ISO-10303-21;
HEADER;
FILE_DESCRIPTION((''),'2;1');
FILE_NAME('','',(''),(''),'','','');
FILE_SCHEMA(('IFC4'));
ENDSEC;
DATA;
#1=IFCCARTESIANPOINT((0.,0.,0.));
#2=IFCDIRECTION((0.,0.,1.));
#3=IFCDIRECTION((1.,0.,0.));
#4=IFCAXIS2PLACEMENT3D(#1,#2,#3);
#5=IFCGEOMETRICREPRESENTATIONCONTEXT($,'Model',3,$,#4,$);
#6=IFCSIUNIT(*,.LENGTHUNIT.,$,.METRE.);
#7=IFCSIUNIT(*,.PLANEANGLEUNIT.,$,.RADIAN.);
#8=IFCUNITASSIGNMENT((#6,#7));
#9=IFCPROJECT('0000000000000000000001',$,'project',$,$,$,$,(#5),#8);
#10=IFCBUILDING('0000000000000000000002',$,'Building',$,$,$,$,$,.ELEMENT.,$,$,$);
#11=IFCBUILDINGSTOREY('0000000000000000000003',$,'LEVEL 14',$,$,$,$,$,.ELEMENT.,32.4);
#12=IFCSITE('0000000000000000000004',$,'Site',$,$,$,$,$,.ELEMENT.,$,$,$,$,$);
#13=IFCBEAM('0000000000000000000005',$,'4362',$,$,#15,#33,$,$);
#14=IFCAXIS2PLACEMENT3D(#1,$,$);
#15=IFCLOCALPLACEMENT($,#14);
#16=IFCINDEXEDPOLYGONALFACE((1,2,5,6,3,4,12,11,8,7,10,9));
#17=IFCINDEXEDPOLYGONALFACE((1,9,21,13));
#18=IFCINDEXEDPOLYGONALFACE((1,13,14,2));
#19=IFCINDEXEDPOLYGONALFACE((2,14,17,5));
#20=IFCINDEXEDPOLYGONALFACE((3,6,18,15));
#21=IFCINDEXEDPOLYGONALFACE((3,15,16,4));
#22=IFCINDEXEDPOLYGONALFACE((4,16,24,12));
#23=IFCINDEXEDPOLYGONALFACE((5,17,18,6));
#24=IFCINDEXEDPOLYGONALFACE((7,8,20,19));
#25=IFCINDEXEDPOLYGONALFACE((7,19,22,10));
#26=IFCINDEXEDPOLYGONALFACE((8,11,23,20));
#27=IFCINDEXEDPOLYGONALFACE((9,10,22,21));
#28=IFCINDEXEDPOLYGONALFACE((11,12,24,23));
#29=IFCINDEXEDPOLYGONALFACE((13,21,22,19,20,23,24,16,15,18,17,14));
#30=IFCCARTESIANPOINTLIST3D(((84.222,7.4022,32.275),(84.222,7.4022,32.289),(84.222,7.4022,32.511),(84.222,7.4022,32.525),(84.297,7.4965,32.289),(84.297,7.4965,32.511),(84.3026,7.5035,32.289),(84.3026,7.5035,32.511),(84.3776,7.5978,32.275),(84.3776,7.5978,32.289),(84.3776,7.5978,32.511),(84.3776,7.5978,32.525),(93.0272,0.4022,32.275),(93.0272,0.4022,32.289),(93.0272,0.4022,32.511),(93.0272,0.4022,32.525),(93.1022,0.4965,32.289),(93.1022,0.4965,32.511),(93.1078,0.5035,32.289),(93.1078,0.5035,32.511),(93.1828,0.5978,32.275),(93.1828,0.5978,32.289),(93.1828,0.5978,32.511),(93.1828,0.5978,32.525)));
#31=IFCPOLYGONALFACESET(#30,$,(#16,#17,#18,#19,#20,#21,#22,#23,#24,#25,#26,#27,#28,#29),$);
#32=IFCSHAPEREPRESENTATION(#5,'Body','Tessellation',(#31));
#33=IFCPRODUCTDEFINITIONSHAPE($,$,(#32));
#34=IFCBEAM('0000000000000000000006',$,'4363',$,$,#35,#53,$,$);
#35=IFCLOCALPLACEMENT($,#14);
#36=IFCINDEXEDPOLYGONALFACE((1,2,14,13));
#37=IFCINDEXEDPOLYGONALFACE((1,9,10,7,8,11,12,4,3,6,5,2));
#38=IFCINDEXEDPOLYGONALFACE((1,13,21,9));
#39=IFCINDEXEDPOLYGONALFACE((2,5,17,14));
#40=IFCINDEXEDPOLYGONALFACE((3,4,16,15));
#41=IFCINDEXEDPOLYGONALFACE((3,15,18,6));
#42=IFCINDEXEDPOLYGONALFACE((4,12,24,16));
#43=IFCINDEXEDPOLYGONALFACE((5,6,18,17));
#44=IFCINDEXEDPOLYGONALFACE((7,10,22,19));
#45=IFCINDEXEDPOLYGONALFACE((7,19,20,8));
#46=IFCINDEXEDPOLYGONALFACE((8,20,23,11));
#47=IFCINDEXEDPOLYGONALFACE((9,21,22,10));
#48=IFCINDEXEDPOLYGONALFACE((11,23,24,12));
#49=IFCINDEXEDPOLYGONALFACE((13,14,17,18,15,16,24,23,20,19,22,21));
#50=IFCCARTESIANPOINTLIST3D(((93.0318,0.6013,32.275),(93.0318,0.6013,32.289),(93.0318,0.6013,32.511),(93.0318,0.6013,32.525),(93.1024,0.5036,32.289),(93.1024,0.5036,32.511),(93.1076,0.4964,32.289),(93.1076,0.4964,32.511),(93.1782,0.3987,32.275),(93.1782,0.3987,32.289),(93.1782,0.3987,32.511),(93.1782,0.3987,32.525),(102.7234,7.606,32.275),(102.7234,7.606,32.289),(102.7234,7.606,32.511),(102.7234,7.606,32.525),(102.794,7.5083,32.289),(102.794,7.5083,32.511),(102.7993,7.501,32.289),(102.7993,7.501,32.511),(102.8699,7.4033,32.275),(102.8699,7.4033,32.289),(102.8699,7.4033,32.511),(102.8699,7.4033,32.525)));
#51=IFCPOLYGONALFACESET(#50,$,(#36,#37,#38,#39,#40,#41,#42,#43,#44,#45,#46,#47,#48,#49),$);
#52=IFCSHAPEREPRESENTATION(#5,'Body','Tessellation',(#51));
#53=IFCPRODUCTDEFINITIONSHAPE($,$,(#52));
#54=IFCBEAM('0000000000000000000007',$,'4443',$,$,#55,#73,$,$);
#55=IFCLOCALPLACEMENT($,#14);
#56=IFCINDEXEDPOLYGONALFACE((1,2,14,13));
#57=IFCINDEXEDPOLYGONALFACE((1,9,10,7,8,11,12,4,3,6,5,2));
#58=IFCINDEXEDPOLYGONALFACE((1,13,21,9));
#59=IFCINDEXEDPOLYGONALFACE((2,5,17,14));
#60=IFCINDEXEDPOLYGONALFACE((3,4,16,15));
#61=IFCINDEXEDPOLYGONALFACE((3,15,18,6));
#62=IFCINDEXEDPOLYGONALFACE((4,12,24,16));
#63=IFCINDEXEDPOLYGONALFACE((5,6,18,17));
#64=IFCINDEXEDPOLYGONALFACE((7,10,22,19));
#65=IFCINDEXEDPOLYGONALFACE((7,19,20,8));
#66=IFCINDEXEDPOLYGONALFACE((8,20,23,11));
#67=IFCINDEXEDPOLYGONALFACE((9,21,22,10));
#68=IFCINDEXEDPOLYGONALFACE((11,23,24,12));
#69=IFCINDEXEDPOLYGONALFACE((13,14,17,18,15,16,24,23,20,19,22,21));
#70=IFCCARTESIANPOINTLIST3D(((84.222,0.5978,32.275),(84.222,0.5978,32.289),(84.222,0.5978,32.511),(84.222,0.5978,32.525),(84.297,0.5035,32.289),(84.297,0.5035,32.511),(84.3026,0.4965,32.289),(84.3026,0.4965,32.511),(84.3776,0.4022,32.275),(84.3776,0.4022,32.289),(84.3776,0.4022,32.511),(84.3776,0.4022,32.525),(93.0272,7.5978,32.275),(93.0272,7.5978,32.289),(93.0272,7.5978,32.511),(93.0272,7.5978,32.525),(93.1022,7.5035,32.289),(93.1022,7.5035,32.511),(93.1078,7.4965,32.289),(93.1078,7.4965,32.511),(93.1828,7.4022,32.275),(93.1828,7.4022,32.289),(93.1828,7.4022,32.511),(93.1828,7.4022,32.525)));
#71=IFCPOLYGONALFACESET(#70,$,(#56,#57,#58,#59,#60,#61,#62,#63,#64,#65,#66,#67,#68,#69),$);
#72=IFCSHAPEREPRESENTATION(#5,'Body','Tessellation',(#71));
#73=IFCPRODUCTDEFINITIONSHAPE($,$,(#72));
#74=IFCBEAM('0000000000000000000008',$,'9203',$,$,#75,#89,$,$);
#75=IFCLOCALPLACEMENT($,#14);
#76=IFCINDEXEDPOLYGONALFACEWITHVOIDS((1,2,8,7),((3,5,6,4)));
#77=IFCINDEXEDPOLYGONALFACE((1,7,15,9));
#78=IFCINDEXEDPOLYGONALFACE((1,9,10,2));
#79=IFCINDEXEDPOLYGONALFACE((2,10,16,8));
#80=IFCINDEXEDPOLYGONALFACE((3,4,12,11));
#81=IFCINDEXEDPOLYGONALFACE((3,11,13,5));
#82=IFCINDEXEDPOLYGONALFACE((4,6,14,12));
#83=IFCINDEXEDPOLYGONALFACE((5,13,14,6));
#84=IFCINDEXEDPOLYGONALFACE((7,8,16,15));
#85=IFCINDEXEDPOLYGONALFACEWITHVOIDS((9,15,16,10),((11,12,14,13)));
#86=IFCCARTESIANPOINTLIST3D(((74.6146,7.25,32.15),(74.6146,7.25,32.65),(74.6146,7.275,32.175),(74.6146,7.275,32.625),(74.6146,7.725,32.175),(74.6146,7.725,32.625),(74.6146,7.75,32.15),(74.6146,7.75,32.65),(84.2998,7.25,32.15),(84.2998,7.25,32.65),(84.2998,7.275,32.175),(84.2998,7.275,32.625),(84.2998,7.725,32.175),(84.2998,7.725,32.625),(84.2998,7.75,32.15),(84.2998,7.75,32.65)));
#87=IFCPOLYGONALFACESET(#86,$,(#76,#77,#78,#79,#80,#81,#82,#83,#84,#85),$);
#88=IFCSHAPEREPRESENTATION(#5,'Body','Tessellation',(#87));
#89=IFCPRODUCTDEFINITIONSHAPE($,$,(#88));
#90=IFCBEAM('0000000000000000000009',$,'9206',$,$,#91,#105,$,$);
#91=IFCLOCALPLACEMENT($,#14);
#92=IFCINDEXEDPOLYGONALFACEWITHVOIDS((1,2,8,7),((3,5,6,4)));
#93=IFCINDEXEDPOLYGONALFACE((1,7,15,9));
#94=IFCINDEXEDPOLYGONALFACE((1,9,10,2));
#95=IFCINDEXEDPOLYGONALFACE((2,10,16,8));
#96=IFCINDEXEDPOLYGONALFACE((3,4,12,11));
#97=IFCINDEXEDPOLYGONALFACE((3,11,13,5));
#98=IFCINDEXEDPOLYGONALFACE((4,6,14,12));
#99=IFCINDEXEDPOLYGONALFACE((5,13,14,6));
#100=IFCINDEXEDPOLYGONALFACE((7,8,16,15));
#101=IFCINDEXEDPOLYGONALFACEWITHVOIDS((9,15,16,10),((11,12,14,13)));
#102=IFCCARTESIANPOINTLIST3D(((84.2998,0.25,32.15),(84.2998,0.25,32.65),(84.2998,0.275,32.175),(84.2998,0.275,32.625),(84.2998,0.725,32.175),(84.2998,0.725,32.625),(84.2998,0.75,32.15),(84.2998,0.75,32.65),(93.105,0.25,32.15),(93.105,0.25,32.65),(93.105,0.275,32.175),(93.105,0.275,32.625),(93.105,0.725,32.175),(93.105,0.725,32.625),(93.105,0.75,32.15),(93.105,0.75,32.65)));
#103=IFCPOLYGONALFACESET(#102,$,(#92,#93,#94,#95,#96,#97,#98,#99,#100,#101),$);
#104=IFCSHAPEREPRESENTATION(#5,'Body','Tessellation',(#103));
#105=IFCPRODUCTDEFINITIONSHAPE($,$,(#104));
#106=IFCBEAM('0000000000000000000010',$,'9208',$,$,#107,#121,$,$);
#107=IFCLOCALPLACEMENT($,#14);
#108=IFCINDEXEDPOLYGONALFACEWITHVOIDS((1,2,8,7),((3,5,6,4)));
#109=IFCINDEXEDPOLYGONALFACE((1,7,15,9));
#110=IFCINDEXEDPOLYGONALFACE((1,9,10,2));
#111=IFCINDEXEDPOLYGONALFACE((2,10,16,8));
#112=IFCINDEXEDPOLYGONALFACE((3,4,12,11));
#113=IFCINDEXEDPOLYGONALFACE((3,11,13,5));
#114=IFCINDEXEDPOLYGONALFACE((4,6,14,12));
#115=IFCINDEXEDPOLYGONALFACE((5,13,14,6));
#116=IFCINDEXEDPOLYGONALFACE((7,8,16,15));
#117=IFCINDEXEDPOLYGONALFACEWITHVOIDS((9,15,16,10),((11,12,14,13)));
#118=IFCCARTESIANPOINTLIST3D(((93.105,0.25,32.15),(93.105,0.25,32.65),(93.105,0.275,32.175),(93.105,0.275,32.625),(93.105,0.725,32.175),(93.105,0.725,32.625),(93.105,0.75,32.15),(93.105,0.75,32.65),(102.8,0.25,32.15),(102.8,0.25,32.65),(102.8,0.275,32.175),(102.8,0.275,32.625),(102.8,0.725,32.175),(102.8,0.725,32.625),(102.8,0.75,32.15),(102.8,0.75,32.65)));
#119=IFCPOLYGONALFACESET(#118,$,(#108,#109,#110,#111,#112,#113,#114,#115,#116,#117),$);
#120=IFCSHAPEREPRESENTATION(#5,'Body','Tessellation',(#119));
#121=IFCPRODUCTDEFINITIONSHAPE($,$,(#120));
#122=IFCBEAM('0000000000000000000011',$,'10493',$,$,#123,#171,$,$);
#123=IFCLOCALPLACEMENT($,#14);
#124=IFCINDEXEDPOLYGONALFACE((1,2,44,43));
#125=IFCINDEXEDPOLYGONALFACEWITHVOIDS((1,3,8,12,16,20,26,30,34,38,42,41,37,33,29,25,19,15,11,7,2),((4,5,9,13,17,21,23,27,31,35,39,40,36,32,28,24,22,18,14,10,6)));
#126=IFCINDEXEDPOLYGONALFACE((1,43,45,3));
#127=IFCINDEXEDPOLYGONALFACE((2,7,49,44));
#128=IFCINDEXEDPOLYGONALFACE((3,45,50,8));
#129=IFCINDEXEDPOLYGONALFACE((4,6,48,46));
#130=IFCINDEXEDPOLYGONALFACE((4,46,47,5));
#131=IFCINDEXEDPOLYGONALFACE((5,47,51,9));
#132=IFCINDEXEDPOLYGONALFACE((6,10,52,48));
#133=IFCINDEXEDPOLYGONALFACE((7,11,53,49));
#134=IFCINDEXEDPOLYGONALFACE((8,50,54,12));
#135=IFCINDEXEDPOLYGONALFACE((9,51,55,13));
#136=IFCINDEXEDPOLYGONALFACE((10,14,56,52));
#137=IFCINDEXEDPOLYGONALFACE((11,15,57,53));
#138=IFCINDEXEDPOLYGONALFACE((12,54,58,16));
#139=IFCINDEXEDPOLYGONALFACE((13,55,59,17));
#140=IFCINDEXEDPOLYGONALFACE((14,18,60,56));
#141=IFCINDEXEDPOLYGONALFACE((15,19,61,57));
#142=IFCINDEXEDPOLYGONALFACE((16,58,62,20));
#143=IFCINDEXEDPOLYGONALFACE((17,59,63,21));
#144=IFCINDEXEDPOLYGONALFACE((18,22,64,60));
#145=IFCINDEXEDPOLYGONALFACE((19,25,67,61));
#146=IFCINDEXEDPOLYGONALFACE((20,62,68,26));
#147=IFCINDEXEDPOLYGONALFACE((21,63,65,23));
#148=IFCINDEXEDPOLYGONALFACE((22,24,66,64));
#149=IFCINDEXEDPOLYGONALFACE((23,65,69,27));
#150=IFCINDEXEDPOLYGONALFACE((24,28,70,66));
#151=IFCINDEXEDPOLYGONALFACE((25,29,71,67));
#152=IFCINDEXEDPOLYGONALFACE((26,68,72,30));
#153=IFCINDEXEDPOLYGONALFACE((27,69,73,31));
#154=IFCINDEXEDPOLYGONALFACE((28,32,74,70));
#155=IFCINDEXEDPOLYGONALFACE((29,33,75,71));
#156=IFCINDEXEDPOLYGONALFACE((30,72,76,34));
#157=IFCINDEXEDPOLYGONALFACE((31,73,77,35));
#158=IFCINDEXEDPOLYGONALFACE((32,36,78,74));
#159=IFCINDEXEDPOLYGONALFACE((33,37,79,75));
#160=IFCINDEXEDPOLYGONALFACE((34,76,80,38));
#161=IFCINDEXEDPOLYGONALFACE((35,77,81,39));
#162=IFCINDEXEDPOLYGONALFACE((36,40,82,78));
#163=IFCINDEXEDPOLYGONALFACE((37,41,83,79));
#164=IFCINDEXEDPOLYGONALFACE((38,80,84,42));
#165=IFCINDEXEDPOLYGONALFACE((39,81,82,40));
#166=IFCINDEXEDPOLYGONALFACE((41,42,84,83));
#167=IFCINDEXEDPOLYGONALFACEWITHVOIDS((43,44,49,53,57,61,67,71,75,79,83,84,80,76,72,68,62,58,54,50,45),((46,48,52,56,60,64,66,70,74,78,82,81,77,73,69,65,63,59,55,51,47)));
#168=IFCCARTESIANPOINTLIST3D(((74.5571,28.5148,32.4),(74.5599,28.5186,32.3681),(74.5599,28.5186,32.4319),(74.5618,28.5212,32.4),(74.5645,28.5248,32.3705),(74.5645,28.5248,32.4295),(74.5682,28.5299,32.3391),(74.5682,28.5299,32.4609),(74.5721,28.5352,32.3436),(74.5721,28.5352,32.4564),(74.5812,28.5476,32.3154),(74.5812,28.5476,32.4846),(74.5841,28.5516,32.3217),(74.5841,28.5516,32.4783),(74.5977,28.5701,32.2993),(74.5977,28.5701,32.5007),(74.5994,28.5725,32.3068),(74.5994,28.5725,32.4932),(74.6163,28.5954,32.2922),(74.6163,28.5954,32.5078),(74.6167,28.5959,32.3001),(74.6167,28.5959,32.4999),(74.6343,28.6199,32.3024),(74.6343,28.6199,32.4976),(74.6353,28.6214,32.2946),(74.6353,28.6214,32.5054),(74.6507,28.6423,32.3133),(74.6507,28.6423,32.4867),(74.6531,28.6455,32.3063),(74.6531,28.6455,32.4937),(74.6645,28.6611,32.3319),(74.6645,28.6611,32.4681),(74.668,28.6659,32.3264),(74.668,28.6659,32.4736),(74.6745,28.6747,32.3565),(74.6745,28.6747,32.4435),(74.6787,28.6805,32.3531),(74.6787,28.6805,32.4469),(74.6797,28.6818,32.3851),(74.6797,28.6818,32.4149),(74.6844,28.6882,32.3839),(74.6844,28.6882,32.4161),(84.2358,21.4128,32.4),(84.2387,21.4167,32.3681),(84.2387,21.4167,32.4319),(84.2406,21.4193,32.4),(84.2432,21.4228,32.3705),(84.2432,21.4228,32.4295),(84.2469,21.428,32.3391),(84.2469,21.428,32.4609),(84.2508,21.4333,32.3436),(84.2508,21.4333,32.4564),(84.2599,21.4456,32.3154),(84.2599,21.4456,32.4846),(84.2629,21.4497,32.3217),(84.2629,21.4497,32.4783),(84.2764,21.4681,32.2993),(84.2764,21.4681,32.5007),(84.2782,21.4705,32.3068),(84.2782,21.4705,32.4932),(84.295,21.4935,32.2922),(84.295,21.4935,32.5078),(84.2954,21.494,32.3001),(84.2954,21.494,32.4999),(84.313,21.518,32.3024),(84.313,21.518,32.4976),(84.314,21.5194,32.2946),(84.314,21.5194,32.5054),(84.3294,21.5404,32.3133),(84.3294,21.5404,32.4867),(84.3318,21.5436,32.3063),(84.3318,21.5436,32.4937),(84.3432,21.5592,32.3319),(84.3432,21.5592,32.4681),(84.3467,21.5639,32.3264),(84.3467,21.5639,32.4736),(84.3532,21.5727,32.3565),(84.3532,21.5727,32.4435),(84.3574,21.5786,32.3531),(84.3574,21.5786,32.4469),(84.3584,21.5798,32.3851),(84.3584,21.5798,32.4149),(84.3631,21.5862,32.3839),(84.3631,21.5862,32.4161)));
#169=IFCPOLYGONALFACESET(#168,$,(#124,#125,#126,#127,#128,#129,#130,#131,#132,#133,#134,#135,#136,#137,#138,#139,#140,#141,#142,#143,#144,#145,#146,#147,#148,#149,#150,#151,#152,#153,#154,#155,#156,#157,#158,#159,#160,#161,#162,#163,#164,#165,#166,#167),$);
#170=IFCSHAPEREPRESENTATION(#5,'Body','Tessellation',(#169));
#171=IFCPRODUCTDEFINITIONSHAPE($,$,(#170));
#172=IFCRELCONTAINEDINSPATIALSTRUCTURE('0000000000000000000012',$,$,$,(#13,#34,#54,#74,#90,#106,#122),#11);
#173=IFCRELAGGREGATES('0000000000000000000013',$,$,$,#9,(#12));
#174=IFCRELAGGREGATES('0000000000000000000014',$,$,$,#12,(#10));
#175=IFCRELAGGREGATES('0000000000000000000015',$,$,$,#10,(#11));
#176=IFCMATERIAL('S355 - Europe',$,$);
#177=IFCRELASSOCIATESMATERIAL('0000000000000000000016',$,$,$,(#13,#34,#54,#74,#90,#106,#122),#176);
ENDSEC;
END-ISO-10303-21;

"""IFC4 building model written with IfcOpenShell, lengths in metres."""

from ifc_helpers import new_model, si_unit, frame, origin_with_axes, origin_2d_with_axis, place, context, project, spatial, hollow_rectangle, hollow_circle, i_section, extrude, material, material_profile, profile_set, profile_usage, element, save


model = new_model("IFC4")

# Units and contexts
model_context = context("Model", 3, world=origin_with_axes())
ifc_project = project(units=[si_unit("LENGTHUNIT", "METRE"), si_unit("PLANEANGLEUNIT", "RADIAN")], contexts=[model_context])

# Site, building, storey
site = spatial("IfcSite", under=ifc_project, Name="Site", CompositionType="ELEMENT")
building = spatial("IfcBuilding", under=site, Name="Building", CompositionType="ELEMENT")
storey = spatial("IfcBuildingStorey", under=building, Name="LEVEL 14", CompositionType="ELEMENT", Elevation=32.4)

# Shared definitions
ifc_material = material(Name="S355 - Europe")

# Beams
ifc_material_profile_1 = material_profile(ifc_material, i_section(OverallWidth=0.25, OverallDepth=0.25, WebThickness=0.009, FlangeThickness=0.014, at=origin_2d_with_axis()))
ifc_profile_set_1 = profile_set([ifc_material_profile_1])
ifc_profile_usage_1 = profile_usage(ifc_profile_set_1, cardinal=10)
beam_1_placement = place(None, frame((84.2998, 7.5, 32.4), z_axis=(0.78278, -0.622298, 0.0), x_axis=(0.622298, 0.78278, 0.0)))
element("IfcBeam", 1, at=beam_1_placement, inside=storey, material=ifc_profile_usage_1, Name="4362", context=model_context, shape_type="SweptSolid", body=[
    extrude(i_section(OverallWidth=0.25, OverallDepth=0.25, WebThickness=0.009, FlangeThickness=0.014, at=origin_2d_with_axis()), origin_with_axes(), (0.0, 0.0, 1.0), 11.2486),
])
ifc_material_profile_2 = material_profile(ifc_material, i_section(OverallWidth=0.25, OverallDepth=0.25, WebThickness=0.009, FlangeThickness=0.014, at=origin_2d_with_axis()))
ifc_profile_set_2 = profile_set([ifc_material_profile_2])
ifc_profile_usage_2 = profile_usage(ifc_profile_set_2, cardinal=10)
beam_2_placement = place(None, frame((93.105, 0.5, 32.4), z_axis=(0.810475, 0.585773, 0.0), x_axis=(-0.585773, 0.810475, 0.0)))
element("IfcBeam", 2, at=beam_2_placement, inside=storey, material=ifc_profile_usage_2, Name="4363", context=model_context, shape_type="SweptSolid", body=[
    extrude(i_section(OverallWidth=0.25, OverallDepth=0.25, WebThickness=0.009, FlangeThickness=0.014, at=origin_2d_with_axis()), origin_with_axes(), (0.0, 0.0, 1.0), 11.958),
])
ifc_material_profile_3 = material_profile(ifc_material, i_section(OverallWidth=0.25, OverallDepth=0.25, WebThickness=0.009, FlangeThickness=0.014, at=origin_2d_with_axis()))
ifc_profile_set_3 = profile_set([ifc_material_profile_3])
ifc_profile_usage_3 = profile_usage(ifc_profile_set_3, cardinal=10)
beam_3_placement = place(None, frame((84.2998, 0.5, 32.4), z_axis=(0.78278, 0.622298, 0.0), x_axis=(-0.622298, 0.78278, 0.0)))
element("IfcBeam", 3, at=beam_3_placement, inside=storey, material=ifc_profile_usage_3, Name="4443", context=model_context, shape_type="SweptSolid", body=[
    extrude(i_section(OverallWidth=0.25, OverallDepth=0.25, WebThickness=0.009, FlangeThickness=0.014, at=origin_2d_with_axis()), origin_with_axes(), (0.0, 0.0, 1.0), 11.2486),
])
ifc_material_profile_4 = material_profile(ifc_material, hollow_rectangle(XDim=0.5, YDim=0.5, WallThickness=0.025, at=origin_2d_with_axis()))
ifc_profile_set_4 = profile_set([ifc_material_profile_4])
ifc_profile_usage_4 = profile_usage(ifc_profile_set_4, cardinal=10)
beam_4_placement = place(None, frame((84.2998, 7.5, 32.4), z_axis=(-1.0, 0.0, 0.0), x_axis=(0.0, -1.0, 0.0)))
element("IfcBeam", 4, at=beam_4_placement, inside=storey, material=ifc_profile_usage_4, Name="9203", context=model_context, shape_type="SweptSolid", body=[
    extrude(hollow_rectangle(XDim=0.5, YDim=0.5, WallThickness=0.025, at=origin_2d_with_axis()), origin_with_axes(), (0.0, 0.0, 1.0), 9.6852),
])
ifc_material_profile_5 = material_profile(ifc_material, hollow_rectangle(XDim=0.5, YDim=0.5, WallThickness=0.025, at=origin_2d_with_axis()))
ifc_profile_set_5 = profile_set([ifc_material_profile_5])
ifc_profile_usage_5 = profile_usage(ifc_profile_set_5, cardinal=10)
beam_5_placement = place(None, frame((84.2998, 0.5, 32.4), z_axis=(1.0, 0.0, 0.0), x_axis=(0.0, 1.0, 0.0)))
element("IfcBeam", 5, at=beam_5_placement, inside=storey, material=ifc_profile_usage_5, Name="9206", context=model_context, shape_type="SweptSolid", body=[
    extrude(hollow_rectangle(XDim=0.5, YDim=0.5, WallThickness=0.025, at=origin_2d_with_axis()), origin_with_axes(), (0.0, 0.0, 1.0), 8.8052),
])
ifc_material_profile_6 = material_profile(ifc_material, hollow_rectangle(XDim=0.5, YDim=0.5, WallThickness=0.025, at=origin_2d_with_axis()))
ifc_profile_set_6 = profile_set([ifc_material_profile_6])
ifc_profile_usage_6 = profile_usage(ifc_profile_set_6, cardinal=10)
beam_6_placement = place(None, frame((93.105, 0.5, 32.4), z_axis=(1.0, 0.0, 0.0), x_axis=(0.0, 1.0, 0.0)))
element("IfcBeam", 6, at=beam_6_placement, inside=storey, material=ifc_profile_usage_6, Name="9208", context=model_context, shape_type="SweptSolid", body=[
    extrude(hollow_rectangle(XDim=0.5, YDim=0.5, WallThickness=0.025, at=origin_2d_with_axis()), origin_with_axes(), (0.0, 0.0, 1.0), 9.695),
])
ifc_material_profile_7 = material_profile(ifc_material, hollow_circle(Radius=0.1081, WallThickness=0.008, at=origin_2d_with_axis()))
ifc_profile_set_7 = profile_set([ifc_material_profile_7])
ifc_profile_usage_7 = profile_usage(ifc_profile_set_7, cardinal=10)
beam_7_placement = place(None, frame((84.2998, 21.5, 32.4), z_axis=(-0.806237, 0.591593, 0.0), x_axis=(-0.591449, -0.806343, 0.0)))
element("IfcBeam", 7, at=beam_7_placement, inside=storey, material=ifc_profile_usage_7, Name="10493", context=model_context, shape_type="SweptSolid", body=[
    extrude(hollow_circle(Radius=0.1081, WallThickness=0.008, at=origin_2d_with_axis()), origin_with_axes(), (0.0, 0.0, 1.0), 12.0048),
])

save(model, "model.ifc")
